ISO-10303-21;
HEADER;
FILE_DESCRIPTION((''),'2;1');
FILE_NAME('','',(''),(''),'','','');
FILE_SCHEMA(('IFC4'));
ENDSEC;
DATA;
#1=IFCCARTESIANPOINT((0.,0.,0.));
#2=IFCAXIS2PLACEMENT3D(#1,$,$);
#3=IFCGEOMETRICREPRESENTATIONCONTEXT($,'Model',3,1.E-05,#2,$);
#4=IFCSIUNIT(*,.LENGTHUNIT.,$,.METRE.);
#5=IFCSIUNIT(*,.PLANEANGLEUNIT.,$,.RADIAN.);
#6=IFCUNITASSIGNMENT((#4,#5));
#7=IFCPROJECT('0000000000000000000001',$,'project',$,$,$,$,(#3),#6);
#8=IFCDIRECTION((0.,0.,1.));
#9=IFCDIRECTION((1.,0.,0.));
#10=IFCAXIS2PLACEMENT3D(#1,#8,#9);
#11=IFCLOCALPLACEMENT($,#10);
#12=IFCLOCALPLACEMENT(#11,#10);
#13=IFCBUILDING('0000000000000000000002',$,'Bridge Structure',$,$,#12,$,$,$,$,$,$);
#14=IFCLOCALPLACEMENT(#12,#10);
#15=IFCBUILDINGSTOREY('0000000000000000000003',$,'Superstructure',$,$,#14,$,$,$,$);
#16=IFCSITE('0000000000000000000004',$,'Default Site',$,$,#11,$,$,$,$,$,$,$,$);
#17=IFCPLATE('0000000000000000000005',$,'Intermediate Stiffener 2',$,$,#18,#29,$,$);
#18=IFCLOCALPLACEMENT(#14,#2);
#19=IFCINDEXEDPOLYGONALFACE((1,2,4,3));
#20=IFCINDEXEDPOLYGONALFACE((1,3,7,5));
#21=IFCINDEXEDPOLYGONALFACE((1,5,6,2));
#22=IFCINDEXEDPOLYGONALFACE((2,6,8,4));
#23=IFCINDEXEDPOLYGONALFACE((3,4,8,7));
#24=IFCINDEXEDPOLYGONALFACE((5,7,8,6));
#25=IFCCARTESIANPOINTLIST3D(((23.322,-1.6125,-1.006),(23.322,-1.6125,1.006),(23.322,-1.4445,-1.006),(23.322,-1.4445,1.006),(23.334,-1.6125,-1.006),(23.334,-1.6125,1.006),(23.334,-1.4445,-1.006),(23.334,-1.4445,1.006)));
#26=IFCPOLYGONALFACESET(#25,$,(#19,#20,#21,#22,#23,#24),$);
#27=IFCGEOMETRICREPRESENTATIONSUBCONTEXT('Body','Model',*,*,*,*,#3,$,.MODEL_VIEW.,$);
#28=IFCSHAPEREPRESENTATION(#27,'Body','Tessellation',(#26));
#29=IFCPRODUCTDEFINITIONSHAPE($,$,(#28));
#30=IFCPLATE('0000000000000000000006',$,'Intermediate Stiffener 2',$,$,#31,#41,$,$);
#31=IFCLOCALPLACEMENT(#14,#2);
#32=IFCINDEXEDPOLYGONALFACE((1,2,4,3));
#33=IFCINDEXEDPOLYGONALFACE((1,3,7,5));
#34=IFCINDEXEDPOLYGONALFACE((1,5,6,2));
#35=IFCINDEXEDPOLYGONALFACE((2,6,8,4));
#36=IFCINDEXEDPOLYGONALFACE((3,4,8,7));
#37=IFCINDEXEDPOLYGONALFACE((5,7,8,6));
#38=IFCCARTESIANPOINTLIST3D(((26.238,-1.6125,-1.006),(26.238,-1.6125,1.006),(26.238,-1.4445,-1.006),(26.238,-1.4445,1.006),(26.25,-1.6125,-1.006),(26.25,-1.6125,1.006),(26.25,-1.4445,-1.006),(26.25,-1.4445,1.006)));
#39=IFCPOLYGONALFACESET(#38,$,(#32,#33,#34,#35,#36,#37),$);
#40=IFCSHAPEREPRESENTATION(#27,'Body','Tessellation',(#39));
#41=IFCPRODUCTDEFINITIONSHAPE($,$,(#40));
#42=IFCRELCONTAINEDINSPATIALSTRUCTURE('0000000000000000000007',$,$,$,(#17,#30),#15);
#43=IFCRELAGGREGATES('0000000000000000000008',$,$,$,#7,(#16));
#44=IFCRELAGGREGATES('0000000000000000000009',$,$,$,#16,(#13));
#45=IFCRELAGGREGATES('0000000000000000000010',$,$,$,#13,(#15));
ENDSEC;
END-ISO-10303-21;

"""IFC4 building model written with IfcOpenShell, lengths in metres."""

from ifc_helpers import new_model, si_unit, frame, origin, origin_with_axes, origin_2d_with_axis, place, context, subcontext, project, spatial, rectangle, extrude, element, save


model = new_model("IFC4")

# Units and contexts
model_context = context("Model", 3, precision=1e-05, world=origin())
body_context = subcontext(model_context, "Body", "Model", "MODEL_VIEW")
ifc_project = project(units=[si_unit("LENGTHUNIT", "METRE"), si_unit("PLANEANGLEUNIT", "RADIAN")], contexts=[model_context])

# Site, building, storey
site_placement = place(None, origin_with_axes())
site = spatial("IfcSite", under=ifc_project, at=site_placement, Name="Default Site")
building_placement = place(site_placement, origin_with_axes())
building = spatial("IfcBuilding", under=site, at=building_placement, Name="Bridge Structure")
storey_placement = place(building_placement, origin_with_axes())
storey = spatial("IfcBuildingStorey", under=building, at=storey_placement, Name="Superstructure")

# Plates
for number, where, z_axis, x_axis, name in (
    (1, (23.328, -1.5285, -1.006), (0.0, 0.0, 1.0), (1.0, 0.0, 0.0), "Intermediate Stiffener 2"),
    (2, (26.244, -1.5285, -1.006), (0.0, 0.0, 1.0), (1.0, 0.0, 0.0), "Intermediate Stiffener 2"),
):
    element("IfcPlate", number, at=place(storey_placement, frame(where, z_axis=z_axis, x_axis=x_axis)), inside=storey, Name=name, context=body_context, shape_type="SweptSolid", body=[
        extrude(rectangle(XDim=0.012, YDim=0.168, at=origin_2d_with_axis()), origin_with_axes(), (0.0, 0.0, 1.0), 2.012),
    ])

save(model, "model.ifc")
